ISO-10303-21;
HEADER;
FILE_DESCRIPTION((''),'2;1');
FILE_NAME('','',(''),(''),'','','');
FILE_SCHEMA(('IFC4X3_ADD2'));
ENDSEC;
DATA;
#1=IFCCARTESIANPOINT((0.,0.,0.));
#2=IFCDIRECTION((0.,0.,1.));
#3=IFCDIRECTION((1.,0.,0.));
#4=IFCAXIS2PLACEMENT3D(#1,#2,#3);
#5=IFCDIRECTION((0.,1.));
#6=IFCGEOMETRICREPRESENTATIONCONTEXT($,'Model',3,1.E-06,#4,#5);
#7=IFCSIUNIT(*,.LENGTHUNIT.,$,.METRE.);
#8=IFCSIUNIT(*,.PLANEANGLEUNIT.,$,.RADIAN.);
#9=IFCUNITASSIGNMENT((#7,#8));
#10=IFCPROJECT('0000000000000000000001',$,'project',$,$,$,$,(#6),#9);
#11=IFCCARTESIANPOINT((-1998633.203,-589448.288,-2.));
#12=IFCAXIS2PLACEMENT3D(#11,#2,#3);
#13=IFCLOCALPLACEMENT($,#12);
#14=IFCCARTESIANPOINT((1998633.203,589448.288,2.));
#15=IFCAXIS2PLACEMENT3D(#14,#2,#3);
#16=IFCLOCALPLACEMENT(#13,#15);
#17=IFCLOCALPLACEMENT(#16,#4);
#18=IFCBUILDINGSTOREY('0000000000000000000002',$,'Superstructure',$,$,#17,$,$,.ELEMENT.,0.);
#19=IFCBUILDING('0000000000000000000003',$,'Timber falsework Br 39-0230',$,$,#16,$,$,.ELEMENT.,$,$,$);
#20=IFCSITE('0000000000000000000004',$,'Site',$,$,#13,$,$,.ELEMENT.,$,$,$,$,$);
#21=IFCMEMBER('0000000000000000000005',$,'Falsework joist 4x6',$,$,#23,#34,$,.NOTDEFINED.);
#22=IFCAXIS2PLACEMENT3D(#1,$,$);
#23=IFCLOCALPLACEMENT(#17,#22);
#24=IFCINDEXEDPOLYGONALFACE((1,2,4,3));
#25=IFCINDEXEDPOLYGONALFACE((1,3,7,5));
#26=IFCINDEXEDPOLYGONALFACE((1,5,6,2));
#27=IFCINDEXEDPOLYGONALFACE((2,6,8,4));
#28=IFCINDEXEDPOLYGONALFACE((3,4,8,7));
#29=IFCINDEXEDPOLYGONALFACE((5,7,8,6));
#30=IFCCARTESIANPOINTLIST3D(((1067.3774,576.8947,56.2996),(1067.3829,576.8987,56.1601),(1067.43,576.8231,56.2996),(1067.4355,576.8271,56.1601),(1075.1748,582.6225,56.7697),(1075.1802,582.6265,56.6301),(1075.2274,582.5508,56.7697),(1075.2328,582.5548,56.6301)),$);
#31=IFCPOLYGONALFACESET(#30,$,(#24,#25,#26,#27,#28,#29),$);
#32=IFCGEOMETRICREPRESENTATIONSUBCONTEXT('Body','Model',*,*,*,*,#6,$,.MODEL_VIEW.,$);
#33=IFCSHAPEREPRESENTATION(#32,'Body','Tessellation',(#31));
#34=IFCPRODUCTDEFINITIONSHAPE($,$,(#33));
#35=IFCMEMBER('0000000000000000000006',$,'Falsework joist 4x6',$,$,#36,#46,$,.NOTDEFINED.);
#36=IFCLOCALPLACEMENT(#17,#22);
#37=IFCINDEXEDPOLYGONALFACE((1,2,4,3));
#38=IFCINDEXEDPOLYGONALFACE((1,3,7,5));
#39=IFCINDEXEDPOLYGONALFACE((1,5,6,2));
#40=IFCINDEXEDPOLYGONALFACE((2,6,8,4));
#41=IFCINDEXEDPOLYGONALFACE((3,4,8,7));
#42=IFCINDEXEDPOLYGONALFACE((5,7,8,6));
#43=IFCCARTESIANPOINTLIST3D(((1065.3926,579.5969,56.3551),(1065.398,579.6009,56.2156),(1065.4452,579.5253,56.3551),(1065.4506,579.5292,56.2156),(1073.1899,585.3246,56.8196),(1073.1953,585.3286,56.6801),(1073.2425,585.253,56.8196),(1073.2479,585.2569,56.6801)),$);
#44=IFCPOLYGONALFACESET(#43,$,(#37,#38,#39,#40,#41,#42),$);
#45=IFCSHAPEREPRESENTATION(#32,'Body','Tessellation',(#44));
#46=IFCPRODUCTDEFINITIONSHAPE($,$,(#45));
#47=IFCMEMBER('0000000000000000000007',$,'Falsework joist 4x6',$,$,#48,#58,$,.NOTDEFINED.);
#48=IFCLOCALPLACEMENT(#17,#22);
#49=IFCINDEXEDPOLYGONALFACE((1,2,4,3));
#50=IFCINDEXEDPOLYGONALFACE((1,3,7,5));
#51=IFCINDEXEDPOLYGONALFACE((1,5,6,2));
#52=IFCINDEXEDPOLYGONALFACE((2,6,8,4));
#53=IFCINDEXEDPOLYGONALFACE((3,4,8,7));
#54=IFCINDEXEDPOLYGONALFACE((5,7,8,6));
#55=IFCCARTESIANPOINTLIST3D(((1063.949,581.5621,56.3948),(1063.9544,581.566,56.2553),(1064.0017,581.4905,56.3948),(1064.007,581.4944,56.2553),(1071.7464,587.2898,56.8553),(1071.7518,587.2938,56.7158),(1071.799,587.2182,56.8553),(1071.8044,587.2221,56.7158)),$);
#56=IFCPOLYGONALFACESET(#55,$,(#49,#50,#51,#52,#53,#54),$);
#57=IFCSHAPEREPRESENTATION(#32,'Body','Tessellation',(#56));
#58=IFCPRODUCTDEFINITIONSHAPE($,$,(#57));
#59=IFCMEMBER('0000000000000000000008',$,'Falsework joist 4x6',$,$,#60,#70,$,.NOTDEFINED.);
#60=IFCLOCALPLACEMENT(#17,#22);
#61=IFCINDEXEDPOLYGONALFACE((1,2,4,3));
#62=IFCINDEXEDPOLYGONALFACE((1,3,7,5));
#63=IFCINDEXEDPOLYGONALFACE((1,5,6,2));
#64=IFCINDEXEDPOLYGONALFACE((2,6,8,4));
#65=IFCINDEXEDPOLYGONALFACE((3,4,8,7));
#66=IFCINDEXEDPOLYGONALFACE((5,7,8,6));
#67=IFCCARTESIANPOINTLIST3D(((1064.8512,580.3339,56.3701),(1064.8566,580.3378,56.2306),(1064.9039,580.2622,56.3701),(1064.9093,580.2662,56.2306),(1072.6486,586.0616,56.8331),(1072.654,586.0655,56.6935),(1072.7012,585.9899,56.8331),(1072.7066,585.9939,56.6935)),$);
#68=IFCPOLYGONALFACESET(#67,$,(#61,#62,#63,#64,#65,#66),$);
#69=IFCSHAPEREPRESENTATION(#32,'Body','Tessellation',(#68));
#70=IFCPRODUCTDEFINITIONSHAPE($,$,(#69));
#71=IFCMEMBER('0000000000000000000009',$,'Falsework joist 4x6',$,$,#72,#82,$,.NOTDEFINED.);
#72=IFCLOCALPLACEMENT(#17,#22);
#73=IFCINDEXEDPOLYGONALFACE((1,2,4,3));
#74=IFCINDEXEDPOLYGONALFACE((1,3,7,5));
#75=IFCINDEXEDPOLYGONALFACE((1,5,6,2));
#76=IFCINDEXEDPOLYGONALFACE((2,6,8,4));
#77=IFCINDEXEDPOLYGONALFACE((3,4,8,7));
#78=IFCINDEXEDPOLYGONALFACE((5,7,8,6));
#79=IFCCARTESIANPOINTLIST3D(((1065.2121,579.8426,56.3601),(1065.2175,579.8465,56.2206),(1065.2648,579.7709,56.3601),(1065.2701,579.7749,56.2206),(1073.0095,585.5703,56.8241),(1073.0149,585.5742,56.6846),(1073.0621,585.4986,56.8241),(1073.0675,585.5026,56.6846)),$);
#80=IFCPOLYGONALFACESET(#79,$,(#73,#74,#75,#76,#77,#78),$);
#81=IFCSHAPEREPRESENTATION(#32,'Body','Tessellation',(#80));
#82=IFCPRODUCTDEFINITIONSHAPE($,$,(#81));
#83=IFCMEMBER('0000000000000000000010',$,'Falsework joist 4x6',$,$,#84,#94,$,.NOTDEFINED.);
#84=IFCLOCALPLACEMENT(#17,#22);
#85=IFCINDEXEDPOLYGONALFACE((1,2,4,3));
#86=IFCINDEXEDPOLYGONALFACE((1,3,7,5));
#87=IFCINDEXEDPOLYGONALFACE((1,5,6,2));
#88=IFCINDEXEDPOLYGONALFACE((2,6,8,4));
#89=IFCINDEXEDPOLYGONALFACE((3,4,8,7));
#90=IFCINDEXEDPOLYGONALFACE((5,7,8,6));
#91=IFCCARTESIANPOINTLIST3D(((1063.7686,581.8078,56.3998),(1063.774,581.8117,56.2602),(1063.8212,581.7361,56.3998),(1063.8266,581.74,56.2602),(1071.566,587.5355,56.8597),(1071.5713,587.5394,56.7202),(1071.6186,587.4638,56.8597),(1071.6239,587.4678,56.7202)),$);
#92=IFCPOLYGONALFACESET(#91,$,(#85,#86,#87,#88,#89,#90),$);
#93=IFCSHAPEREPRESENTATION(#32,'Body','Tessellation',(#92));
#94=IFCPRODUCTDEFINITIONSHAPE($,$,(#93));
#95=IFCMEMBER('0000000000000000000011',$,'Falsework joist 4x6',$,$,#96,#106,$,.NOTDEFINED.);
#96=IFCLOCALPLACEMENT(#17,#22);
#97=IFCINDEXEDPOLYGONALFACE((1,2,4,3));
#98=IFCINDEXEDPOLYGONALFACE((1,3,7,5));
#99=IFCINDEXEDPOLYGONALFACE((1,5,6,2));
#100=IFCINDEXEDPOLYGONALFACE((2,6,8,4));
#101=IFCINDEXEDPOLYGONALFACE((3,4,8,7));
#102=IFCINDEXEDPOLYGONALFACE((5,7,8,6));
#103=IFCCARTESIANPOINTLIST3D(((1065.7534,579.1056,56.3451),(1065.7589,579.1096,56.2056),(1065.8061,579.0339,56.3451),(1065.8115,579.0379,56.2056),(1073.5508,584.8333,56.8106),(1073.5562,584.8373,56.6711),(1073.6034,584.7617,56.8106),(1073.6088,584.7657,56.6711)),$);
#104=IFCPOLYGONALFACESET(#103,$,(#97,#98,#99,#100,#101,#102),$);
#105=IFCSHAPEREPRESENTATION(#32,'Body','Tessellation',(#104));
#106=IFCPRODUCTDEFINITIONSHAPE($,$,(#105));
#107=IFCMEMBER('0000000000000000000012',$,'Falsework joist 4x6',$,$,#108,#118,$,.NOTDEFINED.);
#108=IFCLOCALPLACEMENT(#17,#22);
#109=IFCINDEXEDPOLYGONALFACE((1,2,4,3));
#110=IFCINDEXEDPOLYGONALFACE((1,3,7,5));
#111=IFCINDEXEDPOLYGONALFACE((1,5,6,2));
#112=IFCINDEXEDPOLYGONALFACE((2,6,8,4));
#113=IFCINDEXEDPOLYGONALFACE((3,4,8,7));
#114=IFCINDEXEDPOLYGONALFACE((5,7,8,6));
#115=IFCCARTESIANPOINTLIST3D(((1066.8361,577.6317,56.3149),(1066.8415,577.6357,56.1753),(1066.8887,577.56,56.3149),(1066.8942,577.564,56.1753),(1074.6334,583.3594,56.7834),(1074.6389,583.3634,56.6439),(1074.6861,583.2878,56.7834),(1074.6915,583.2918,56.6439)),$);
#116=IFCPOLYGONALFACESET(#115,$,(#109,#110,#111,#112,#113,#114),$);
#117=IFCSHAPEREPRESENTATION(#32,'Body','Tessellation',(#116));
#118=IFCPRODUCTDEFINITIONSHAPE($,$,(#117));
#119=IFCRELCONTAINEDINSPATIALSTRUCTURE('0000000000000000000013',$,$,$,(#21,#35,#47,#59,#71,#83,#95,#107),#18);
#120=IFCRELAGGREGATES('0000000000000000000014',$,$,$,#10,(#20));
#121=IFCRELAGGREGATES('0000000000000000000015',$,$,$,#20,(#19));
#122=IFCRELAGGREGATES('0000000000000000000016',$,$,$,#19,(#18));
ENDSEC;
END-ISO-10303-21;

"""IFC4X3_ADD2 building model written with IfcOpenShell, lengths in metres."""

from ifc_helpers import new_model, si_unit, direction, frame, frame_2d, origin, origin_with_axes, place, context, subcontext, project, spatial, rectangle, extrude, element, save


model = new_model("IFC4X3_ADD2")

# Units and contexts
model_context = context("Model", 3, precision=1e-06, world=origin_with_axes(), true_north=direction((0.0, 1.0)))
body_context = subcontext(model_context, "Body", "Model", "MODEL_VIEW")
ifc_project = project(units=[si_unit("LENGTHUNIT", "METRE"), si_unit("PLANEANGLEUNIT", "RADIAN")], contexts=[model_context])

# Site, building, storey
site_placement = place(None, frame((-1998633.203, -589448.288, -2.0), z_axis=(0.0, 0.0, 1.0), x_axis=(1.0, 0.0, 0.0)))
site = spatial("IfcSite", under=ifc_project, at=site_placement, Name="Site", CompositionType="ELEMENT")
building_placement = place(site_placement, frame((1998633.203, 589448.288, 2.0), z_axis=(0.0, 0.0, 1.0), x_axis=(1.0, 0.0, 0.0)))
building = spatial("IfcBuilding", under=site, at=building_placement, Name="Timber falsework Br 39-0230", CompositionType="ELEMENT")
storey_placement = place(building_placement, origin_with_axes())
storey = spatial("IfcBuildingStorey", under=building, at=storey_placement, Name="Superstructure", CompositionType="ELEMENT", Elevation=0.0)

# Members
member_1_placement = place(storey_placement, frame((1067.4092, 576.8629, 56.1601), z_axis=(0.804979, 0.591316, 0.048527), x_axis=(-0.592013, 0.805928, 0.0)))
element("IfcMember", 1, at=member_1_placement, inside=storey, Name="Falsework joist 4x6", PredefinedType="NOTDEFINED", context=body_context, shape_type="SweptSolid", body=[
    extrude(rectangle(XDim=0.0889, YDim=0.1397, at=frame_2d((0.0, 0.0698))), origin(), (0.0, 0.0, 1.0), 9.6864),
])
member_2_placement = place(storey_placement, frame((1065.4243, 579.565, 56.2156), z_axis=(0.805001, 0.591332, 0.047955), x_axis=(-0.592013, 0.805928, 0.0)))
element("IfcMember", 2, at=member_2_placement, inside=storey, Name="Falsework joist 4x6", PredefinedType="NOTDEFINED", context=body_context, shape_type="SweptSolid", body=[
    extrude(rectangle(XDim=0.0889, YDim=0.1397, at=frame_2d((0.0, 0.0698))), origin(), (0.0, 0.0, 1.0), 9.6861),
])
member_3_placement = place(storey_placement, frame((1063.9807, 581.5302, 56.2553), z_axis=(0.805017, 0.591344, 0.04754), x_axis=(-0.592013, 0.805928, 0.0)))
element("IfcMember", 3, at=member_3_placement, inside=storey, Name="Falsework joist 4x6", PredefinedType="NOTDEFINED", context=body_context, shape_type="SweptSolid", body=[
    extrude(rectangle(XDim=0.0889, YDim=0.1397, at=frame_2d((0.0, 0.0698))), origin(), (0.0, 0.0, 1.0), 9.686),
])
member_4_placement = place(storey_placement, frame((1064.8829, 580.302, 56.2306), z_axis=(0.805007, 0.591336, 0.0478), x_axis=(-0.592013, 0.805928, 0.0)))
element("IfcMember", 4, at=member_4_placement, inside=storey, Name="Falsework joist 4x6", PredefinedType="NOTDEFINED", context=body_context, shape_type="SweptSolid", body=[
    extrude(rectangle(XDim=0.0889, YDim=0.1397, at=frame_2d((0.0, 0.0698))), origin(), (0.0, 0.0, 1.0), 9.6861),
])
member_5_placement = place(storey_placement, frame((1065.2438, 579.8107, 56.2206), z_axis=(0.805003, 0.591334, 0.047903), x_axis=(-0.592013, 0.805928, 0.0)))
element("IfcMember", 5, at=member_5_placement, inside=storey, Name="Falsework joist 4x6", PredefinedType="NOTDEFINED", context=body_context, shape_type="SweptSolid", body=[
    extrude(rectangle(XDim=0.0889, YDim=0.1397, at=frame_2d((0.0, 0.0698))), origin(), (0.0, 0.0, 1.0), 9.6861),
])
member_6_placement = place(storey_placement, frame((1063.8003, 581.7759, 56.2602), z_axis=(0.805019, 0.591345, 0.047488), x_axis=(-0.592013, 0.805928, 0.0)))
element("IfcMember", 6, at=member_6_placement, inside=storey, Name="Falsework joist 4x6", PredefinedType="NOTDEFINED", context=body_context, shape_type="SweptSolid", body=[
    extrude(rectangle(XDim=0.0889, YDim=0.1397, at=frame_2d((0.0, 0.0698))), origin(), (0.0, 0.0, 1.0), 9.6859),
])
member_7_placement = place(storey_placement, frame((1065.7852, 579.0737, 56.2056), z_axis=(0.804997, 0.591329, 0.048059), x_axis=(-0.592013, 0.805928, 0.0)))
element("IfcMember", 7, at=member_7_placement, inside=storey, Name="Falsework joist 4x6", PredefinedType="NOTDEFINED", context=body_context, shape_type="SweptSolid", body=[
    extrude(rectangle(XDim=0.0889, YDim=0.1397, at=frame_2d((0.0, 0.0698))), origin(), (0.0, 0.0, 1.0), 9.6862),
])
member_8_placement = place(storey_placement, frame((1066.8678, 577.5999, 56.1753), z_axis=(0.804985, 0.59132, 0.048371), x_axis=(-0.592013, 0.805928, 0.0)))
element("IfcMember", 8, at=member_8_placement, inside=storey, Name="Falsework joist 4x6", PredefinedType="NOTDEFINED", context=body_context, shape_type="SweptSolid", body=[
    extrude(rectangle(XDim=0.0889, YDim=0.1397, at=frame_2d((0.0, 0.0698))), origin(), (0.0, 0.0, 1.0), 9.6863),
])

save(model, "model.ifc")
